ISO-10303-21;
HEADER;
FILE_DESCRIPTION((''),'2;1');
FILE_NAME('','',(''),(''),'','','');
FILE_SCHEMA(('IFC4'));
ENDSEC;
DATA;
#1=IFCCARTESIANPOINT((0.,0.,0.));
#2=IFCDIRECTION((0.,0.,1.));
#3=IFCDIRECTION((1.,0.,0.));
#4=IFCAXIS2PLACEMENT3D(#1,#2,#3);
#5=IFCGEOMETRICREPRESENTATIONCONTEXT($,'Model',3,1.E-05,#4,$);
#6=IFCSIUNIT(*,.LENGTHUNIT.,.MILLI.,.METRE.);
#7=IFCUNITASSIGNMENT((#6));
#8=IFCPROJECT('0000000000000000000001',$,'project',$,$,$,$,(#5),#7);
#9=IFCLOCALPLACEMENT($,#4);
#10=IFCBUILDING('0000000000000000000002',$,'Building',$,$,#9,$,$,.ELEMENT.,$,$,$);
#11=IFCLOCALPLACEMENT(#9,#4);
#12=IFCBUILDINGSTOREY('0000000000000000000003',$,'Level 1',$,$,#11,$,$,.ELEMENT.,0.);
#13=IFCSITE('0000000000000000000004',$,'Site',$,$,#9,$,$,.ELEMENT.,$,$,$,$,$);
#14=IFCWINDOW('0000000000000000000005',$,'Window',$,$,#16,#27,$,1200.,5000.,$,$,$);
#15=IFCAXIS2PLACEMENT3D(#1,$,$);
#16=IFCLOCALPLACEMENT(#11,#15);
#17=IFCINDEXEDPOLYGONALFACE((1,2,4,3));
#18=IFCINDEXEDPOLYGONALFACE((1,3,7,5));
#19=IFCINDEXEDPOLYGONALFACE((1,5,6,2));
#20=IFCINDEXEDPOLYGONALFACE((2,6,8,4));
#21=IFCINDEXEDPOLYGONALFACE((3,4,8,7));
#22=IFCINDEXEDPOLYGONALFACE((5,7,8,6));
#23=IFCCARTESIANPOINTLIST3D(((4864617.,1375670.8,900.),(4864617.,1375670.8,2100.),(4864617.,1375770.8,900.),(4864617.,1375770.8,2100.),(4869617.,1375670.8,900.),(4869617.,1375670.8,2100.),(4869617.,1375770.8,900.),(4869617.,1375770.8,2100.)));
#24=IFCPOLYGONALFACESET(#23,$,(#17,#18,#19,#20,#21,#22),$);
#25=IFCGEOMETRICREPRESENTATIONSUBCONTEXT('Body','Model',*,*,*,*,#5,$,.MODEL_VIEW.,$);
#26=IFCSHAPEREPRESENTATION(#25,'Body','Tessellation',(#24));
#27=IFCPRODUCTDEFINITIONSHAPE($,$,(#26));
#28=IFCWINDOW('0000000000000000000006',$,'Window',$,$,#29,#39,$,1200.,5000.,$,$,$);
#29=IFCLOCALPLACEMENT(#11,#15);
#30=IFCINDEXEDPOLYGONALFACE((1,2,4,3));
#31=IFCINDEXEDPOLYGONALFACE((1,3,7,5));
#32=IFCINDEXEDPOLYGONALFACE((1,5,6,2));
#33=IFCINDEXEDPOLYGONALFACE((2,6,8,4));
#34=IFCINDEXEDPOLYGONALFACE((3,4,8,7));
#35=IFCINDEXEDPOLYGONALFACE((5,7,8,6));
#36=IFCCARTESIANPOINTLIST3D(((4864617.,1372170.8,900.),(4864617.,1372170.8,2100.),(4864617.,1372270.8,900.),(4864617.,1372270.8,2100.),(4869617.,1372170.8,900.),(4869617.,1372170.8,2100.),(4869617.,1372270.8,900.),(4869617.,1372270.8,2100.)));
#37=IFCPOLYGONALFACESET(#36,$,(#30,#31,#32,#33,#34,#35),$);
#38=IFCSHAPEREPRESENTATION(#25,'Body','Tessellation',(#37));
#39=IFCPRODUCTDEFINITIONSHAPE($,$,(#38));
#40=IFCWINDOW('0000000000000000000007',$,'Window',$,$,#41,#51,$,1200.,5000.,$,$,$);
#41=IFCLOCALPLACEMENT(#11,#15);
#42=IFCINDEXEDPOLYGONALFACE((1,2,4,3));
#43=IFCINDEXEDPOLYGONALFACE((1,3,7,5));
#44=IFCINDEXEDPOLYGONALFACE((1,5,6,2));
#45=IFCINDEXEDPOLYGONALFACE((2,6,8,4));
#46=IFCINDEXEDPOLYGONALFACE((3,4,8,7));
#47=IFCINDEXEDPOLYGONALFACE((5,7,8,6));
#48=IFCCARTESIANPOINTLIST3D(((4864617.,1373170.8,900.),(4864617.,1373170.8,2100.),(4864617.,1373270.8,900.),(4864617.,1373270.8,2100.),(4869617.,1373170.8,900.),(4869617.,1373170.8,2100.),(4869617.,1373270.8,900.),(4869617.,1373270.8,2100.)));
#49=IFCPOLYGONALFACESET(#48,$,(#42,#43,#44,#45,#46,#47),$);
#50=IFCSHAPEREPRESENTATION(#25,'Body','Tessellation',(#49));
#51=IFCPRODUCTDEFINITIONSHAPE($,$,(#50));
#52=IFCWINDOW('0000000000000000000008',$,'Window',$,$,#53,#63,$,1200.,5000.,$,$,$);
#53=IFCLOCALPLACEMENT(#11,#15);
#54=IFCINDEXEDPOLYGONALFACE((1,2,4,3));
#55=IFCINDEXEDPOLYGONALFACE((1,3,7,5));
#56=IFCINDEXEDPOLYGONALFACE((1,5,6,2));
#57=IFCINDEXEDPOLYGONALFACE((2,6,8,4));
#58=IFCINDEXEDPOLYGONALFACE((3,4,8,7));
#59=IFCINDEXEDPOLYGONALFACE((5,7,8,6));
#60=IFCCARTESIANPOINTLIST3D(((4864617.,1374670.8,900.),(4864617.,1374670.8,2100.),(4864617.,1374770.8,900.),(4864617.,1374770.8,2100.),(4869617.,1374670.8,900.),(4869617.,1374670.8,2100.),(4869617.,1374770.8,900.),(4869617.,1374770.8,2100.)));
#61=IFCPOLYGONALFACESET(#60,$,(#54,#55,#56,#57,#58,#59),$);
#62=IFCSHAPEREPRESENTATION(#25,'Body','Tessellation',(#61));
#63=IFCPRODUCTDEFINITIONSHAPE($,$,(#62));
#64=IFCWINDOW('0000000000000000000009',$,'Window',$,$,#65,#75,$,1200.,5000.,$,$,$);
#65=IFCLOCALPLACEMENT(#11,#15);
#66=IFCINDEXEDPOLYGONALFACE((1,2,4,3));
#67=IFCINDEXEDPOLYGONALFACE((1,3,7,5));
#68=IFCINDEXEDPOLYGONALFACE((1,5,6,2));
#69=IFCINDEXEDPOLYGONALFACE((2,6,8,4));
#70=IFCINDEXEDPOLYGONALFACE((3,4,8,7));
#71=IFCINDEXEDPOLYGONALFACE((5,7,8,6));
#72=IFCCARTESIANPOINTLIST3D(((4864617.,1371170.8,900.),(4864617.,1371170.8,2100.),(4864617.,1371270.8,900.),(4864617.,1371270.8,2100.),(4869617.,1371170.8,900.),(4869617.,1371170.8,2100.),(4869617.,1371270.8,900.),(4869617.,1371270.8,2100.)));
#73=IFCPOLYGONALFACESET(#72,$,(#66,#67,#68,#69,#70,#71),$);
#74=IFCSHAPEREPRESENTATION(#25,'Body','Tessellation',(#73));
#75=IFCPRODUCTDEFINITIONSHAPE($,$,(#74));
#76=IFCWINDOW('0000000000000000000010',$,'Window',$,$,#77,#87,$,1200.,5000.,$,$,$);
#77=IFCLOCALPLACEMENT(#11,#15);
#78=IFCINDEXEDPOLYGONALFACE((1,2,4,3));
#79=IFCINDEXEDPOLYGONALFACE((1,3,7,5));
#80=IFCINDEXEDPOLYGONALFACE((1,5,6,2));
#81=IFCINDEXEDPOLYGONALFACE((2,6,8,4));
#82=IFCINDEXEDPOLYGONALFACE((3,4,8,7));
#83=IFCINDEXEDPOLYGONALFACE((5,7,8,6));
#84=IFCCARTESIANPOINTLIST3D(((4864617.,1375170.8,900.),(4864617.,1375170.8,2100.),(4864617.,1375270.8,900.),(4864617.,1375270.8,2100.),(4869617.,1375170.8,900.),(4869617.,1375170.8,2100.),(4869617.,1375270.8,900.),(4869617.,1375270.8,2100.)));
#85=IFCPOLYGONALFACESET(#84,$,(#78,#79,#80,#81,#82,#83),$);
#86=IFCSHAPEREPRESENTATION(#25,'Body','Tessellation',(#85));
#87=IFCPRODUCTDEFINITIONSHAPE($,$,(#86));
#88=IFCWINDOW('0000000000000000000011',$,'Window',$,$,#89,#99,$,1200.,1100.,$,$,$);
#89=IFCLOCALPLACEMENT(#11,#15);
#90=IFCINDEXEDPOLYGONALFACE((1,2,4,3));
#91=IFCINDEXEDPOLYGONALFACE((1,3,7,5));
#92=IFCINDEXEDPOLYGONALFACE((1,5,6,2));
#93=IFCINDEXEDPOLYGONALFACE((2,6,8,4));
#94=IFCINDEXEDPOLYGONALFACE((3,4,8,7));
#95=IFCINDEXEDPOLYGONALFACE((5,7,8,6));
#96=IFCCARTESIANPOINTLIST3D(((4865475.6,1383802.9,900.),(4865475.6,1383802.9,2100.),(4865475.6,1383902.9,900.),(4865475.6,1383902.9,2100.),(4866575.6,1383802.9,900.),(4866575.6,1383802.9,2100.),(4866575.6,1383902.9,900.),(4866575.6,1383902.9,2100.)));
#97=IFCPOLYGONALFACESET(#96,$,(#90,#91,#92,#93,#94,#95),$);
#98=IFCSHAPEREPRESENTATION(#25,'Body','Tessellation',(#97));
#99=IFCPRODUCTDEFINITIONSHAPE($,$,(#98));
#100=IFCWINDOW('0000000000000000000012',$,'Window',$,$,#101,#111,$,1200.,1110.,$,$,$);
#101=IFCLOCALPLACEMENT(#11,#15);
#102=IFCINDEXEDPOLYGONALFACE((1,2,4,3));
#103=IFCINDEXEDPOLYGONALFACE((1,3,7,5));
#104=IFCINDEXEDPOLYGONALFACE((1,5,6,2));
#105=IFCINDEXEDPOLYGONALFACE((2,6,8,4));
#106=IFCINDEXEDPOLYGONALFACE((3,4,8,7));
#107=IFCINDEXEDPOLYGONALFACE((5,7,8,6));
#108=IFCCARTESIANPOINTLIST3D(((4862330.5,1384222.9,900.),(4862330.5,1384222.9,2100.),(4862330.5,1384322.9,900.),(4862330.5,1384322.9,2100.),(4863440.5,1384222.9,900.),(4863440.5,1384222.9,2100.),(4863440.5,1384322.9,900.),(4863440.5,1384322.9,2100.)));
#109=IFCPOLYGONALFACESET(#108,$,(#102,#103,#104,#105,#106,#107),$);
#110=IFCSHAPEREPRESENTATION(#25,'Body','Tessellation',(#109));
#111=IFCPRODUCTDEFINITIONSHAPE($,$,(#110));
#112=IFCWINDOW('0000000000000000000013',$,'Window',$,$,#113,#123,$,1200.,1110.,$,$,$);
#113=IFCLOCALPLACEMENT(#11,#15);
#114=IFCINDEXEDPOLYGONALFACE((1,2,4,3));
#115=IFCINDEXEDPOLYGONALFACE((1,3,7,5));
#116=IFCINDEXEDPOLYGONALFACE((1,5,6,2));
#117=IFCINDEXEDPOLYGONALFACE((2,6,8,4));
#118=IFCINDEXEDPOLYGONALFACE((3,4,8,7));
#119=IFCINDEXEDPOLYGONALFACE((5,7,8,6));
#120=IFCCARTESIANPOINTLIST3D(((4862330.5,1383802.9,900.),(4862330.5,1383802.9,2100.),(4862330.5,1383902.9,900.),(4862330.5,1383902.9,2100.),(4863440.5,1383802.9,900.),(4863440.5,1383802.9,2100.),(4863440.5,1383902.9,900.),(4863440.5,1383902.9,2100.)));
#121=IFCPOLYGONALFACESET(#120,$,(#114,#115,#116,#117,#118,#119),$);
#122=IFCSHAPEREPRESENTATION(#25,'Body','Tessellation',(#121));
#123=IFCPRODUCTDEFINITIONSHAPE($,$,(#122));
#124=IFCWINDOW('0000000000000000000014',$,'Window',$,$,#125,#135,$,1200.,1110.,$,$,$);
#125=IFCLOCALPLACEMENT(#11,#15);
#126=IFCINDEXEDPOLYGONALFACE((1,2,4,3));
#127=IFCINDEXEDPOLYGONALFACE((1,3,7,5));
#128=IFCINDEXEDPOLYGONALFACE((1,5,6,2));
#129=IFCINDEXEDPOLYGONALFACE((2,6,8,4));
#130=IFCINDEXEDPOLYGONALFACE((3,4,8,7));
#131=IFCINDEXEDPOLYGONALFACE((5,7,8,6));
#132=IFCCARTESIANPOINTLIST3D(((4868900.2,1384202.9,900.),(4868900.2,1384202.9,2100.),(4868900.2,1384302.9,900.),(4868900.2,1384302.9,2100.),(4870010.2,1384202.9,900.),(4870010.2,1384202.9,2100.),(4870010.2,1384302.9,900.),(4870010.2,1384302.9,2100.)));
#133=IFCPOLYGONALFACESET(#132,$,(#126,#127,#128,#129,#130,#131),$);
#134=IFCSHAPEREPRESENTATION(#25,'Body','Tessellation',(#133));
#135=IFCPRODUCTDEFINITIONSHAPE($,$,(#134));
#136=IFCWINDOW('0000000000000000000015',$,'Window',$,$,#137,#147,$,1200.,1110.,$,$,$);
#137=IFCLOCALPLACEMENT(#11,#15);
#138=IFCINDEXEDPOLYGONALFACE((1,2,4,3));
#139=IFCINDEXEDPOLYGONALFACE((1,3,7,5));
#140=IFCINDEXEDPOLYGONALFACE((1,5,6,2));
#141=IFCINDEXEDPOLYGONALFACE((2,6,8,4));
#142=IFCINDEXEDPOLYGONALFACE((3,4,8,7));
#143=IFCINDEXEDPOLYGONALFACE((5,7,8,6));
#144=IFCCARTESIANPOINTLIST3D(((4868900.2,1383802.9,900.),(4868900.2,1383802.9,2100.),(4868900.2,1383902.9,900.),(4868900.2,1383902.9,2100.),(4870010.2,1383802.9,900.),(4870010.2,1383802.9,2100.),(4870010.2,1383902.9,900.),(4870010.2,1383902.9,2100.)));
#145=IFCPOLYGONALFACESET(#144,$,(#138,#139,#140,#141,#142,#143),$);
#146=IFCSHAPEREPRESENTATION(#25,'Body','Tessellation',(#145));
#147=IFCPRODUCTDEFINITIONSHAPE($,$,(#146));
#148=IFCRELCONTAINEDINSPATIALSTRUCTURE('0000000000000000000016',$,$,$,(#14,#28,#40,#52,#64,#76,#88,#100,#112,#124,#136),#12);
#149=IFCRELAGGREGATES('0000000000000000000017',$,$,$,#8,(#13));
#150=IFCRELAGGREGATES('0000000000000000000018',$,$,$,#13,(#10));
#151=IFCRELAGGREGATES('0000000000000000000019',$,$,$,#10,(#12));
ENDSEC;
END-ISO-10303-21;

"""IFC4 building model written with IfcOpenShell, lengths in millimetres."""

from ifc_helpers import new_model, si_unit, frame, frame_2d, origin_with_axes, place, context, subcontext, project, spatial, rectangle, extrude, element, save


model = new_model("IFC4")

# Units and contexts
model_context = context("Model", 3, precision=1e-05, world=origin_with_axes())
body_context = subcontext(model_context, "Body", "Model", "MODEL_VIEW")
ifc_project = project(units=[si_unit("LENGTHUNIT", "METRE", prefix="MILLI")], contexts=[model_context])

# Site, building, storey
placement = place(None, origin_with_axes())
site = spatial("IfcSite", under=ifc_project, at=placement, Name="Site", CompositionType="ELEMENT")
building = spatial("IfcBuilding", under=site, at=placement, Name="Building", CompositionType="ELEMENT")
storey_placement = place(placement, origin_with_axes())
storey = spatial("IfcBuildingStorey", under=building, at=storey_placement, Name="Level 1", CompositionType="ELEMENT", Elevation=0.0)

# Windows
for number, where, z_axis, x_axis, name in (
    (1, (4864617.0, 1375720.8, 900.0), (0.0, 0.0, 1.0), (1.0, 0.0, 0.0), "Window"),
    (2, (4864617.0, 1372220.8, 900.0), (0.0, 0.0, 1.0), (1.0, 0.0, 0.0), "Window"),
    (3, (4864617.0, 1373220.8, 900.0), (0.0, 0.0, 1.0), (1.0, 0.0, 0.0), "Window"),
    (4, (4864617.0, 1374720.8, 900.0), (0.0, 0.0, 1.0), (1.0, 0.0, 0.0), "Window"),
    (5, (4864617.0, 1371220.8, 900.0), (0.0, 0.0, 1.0), (1.0, 0.0, 0.0), "Window"),
    (6, (4864617.0, 1375220.8, 900.0), (0.0, 0.0, 1.0), (1.0, 0.0, 0.0), "Window"),
):
    element("IfcWindow", number, at=place(placement, frame(where, z_axis=z_axis, x_axis=x_axis)), inside=storey, Name=name, OverallHeight=1200.0, OverallWidth=5000.0, context=body_context, shape_type="SweptSolid", body=[
        extrude(rectangle(XDim=5000.0, YDim=100.0, at=frame_2d((2500.0, 0.0), x_axis=(1.0, 0.0))), origin_with_axes(), (0.0, 0.0, 1.0), 1200.0),
    ])
window_placement = place(placement, frame((4865475.6, 1383852.9, 900.0), z_axis=(0.0, 0.0, 1.0), x_axis=(1.0, 0.0, 0.0)))
element("IfcWindow", 7, at=window_placement, inside=storey, Name="Window", OverallHeight=1200.0, OverallWidth=1100.0, context=body_context, shape_type="SweptSolid", body=[
    extrude(rectangle(XDim=1100.0, YDim=100.0, at=frame_2d((550.0, 0.0), x_axis=(1.0, 0.0))), origin_with_axes(), (0.0, 0.0, 1.0), 1200.0),
])
for number, where, z_axis, x_axis, name in (
    (8, (4862330.5, 1384272.9, 900.0), (0.0, 0.0, 1.0), (1.0, 0.0, 0.0), "Window"),
    (9, (4862330.5, 1383852.9, 900.0), (0.0, 0.0, 1.0), (1.0, 0.0, 0.0), "Window"),
):
    element("IfcWindow", number, at=place(placement, frame(where, z_axis=z_axis, x_axis=x_axis)), inside=storey, Name=name, OverallHeight=1200.0, OverallWidth=1110.0, context=body_context, shape_type="SweptSolid", body=[
        extrude(rectangle(XDim=1110.0, YDim=100.0, at=frame_2d((555.0, 0.0), x_axis=(1.0, 0.0))), origin_with_axes(), (0.0, 0.0, 1.0), 1200.0),
    ])
for number, where, z_axis, x_axis, name in (
    (10, (4868900.2, 1384252.9, 900.0), (0.0, 0.0, 1.0), (1.0, 0.0, 0.0), "Window"),
    (11, (4868900.2, 1383852.9, 900.0), (0.0, 0.0, 1.0), (1.0, 0.0, 0.0), "Window"),
):
    element("IfcWindow", number, at=place(placement, frame(where, z_axis=z_axis, x_axis=x_axis)), inside=storey, Name=name, OverallHeight=1200.0, OverallWidth=1110.0, context=body_context, shape_type="SweptSolid", body=[
        extrude(rectangle(XDim=1110.0, YDim=100.0, at=frame_2d((555.0, 0.0), x_axis=(1.0, 0.0))), origin_with_axes(), (0.0, 0.0, 1.0), 1200.0),
    ])

save(model, "model.ifc")
